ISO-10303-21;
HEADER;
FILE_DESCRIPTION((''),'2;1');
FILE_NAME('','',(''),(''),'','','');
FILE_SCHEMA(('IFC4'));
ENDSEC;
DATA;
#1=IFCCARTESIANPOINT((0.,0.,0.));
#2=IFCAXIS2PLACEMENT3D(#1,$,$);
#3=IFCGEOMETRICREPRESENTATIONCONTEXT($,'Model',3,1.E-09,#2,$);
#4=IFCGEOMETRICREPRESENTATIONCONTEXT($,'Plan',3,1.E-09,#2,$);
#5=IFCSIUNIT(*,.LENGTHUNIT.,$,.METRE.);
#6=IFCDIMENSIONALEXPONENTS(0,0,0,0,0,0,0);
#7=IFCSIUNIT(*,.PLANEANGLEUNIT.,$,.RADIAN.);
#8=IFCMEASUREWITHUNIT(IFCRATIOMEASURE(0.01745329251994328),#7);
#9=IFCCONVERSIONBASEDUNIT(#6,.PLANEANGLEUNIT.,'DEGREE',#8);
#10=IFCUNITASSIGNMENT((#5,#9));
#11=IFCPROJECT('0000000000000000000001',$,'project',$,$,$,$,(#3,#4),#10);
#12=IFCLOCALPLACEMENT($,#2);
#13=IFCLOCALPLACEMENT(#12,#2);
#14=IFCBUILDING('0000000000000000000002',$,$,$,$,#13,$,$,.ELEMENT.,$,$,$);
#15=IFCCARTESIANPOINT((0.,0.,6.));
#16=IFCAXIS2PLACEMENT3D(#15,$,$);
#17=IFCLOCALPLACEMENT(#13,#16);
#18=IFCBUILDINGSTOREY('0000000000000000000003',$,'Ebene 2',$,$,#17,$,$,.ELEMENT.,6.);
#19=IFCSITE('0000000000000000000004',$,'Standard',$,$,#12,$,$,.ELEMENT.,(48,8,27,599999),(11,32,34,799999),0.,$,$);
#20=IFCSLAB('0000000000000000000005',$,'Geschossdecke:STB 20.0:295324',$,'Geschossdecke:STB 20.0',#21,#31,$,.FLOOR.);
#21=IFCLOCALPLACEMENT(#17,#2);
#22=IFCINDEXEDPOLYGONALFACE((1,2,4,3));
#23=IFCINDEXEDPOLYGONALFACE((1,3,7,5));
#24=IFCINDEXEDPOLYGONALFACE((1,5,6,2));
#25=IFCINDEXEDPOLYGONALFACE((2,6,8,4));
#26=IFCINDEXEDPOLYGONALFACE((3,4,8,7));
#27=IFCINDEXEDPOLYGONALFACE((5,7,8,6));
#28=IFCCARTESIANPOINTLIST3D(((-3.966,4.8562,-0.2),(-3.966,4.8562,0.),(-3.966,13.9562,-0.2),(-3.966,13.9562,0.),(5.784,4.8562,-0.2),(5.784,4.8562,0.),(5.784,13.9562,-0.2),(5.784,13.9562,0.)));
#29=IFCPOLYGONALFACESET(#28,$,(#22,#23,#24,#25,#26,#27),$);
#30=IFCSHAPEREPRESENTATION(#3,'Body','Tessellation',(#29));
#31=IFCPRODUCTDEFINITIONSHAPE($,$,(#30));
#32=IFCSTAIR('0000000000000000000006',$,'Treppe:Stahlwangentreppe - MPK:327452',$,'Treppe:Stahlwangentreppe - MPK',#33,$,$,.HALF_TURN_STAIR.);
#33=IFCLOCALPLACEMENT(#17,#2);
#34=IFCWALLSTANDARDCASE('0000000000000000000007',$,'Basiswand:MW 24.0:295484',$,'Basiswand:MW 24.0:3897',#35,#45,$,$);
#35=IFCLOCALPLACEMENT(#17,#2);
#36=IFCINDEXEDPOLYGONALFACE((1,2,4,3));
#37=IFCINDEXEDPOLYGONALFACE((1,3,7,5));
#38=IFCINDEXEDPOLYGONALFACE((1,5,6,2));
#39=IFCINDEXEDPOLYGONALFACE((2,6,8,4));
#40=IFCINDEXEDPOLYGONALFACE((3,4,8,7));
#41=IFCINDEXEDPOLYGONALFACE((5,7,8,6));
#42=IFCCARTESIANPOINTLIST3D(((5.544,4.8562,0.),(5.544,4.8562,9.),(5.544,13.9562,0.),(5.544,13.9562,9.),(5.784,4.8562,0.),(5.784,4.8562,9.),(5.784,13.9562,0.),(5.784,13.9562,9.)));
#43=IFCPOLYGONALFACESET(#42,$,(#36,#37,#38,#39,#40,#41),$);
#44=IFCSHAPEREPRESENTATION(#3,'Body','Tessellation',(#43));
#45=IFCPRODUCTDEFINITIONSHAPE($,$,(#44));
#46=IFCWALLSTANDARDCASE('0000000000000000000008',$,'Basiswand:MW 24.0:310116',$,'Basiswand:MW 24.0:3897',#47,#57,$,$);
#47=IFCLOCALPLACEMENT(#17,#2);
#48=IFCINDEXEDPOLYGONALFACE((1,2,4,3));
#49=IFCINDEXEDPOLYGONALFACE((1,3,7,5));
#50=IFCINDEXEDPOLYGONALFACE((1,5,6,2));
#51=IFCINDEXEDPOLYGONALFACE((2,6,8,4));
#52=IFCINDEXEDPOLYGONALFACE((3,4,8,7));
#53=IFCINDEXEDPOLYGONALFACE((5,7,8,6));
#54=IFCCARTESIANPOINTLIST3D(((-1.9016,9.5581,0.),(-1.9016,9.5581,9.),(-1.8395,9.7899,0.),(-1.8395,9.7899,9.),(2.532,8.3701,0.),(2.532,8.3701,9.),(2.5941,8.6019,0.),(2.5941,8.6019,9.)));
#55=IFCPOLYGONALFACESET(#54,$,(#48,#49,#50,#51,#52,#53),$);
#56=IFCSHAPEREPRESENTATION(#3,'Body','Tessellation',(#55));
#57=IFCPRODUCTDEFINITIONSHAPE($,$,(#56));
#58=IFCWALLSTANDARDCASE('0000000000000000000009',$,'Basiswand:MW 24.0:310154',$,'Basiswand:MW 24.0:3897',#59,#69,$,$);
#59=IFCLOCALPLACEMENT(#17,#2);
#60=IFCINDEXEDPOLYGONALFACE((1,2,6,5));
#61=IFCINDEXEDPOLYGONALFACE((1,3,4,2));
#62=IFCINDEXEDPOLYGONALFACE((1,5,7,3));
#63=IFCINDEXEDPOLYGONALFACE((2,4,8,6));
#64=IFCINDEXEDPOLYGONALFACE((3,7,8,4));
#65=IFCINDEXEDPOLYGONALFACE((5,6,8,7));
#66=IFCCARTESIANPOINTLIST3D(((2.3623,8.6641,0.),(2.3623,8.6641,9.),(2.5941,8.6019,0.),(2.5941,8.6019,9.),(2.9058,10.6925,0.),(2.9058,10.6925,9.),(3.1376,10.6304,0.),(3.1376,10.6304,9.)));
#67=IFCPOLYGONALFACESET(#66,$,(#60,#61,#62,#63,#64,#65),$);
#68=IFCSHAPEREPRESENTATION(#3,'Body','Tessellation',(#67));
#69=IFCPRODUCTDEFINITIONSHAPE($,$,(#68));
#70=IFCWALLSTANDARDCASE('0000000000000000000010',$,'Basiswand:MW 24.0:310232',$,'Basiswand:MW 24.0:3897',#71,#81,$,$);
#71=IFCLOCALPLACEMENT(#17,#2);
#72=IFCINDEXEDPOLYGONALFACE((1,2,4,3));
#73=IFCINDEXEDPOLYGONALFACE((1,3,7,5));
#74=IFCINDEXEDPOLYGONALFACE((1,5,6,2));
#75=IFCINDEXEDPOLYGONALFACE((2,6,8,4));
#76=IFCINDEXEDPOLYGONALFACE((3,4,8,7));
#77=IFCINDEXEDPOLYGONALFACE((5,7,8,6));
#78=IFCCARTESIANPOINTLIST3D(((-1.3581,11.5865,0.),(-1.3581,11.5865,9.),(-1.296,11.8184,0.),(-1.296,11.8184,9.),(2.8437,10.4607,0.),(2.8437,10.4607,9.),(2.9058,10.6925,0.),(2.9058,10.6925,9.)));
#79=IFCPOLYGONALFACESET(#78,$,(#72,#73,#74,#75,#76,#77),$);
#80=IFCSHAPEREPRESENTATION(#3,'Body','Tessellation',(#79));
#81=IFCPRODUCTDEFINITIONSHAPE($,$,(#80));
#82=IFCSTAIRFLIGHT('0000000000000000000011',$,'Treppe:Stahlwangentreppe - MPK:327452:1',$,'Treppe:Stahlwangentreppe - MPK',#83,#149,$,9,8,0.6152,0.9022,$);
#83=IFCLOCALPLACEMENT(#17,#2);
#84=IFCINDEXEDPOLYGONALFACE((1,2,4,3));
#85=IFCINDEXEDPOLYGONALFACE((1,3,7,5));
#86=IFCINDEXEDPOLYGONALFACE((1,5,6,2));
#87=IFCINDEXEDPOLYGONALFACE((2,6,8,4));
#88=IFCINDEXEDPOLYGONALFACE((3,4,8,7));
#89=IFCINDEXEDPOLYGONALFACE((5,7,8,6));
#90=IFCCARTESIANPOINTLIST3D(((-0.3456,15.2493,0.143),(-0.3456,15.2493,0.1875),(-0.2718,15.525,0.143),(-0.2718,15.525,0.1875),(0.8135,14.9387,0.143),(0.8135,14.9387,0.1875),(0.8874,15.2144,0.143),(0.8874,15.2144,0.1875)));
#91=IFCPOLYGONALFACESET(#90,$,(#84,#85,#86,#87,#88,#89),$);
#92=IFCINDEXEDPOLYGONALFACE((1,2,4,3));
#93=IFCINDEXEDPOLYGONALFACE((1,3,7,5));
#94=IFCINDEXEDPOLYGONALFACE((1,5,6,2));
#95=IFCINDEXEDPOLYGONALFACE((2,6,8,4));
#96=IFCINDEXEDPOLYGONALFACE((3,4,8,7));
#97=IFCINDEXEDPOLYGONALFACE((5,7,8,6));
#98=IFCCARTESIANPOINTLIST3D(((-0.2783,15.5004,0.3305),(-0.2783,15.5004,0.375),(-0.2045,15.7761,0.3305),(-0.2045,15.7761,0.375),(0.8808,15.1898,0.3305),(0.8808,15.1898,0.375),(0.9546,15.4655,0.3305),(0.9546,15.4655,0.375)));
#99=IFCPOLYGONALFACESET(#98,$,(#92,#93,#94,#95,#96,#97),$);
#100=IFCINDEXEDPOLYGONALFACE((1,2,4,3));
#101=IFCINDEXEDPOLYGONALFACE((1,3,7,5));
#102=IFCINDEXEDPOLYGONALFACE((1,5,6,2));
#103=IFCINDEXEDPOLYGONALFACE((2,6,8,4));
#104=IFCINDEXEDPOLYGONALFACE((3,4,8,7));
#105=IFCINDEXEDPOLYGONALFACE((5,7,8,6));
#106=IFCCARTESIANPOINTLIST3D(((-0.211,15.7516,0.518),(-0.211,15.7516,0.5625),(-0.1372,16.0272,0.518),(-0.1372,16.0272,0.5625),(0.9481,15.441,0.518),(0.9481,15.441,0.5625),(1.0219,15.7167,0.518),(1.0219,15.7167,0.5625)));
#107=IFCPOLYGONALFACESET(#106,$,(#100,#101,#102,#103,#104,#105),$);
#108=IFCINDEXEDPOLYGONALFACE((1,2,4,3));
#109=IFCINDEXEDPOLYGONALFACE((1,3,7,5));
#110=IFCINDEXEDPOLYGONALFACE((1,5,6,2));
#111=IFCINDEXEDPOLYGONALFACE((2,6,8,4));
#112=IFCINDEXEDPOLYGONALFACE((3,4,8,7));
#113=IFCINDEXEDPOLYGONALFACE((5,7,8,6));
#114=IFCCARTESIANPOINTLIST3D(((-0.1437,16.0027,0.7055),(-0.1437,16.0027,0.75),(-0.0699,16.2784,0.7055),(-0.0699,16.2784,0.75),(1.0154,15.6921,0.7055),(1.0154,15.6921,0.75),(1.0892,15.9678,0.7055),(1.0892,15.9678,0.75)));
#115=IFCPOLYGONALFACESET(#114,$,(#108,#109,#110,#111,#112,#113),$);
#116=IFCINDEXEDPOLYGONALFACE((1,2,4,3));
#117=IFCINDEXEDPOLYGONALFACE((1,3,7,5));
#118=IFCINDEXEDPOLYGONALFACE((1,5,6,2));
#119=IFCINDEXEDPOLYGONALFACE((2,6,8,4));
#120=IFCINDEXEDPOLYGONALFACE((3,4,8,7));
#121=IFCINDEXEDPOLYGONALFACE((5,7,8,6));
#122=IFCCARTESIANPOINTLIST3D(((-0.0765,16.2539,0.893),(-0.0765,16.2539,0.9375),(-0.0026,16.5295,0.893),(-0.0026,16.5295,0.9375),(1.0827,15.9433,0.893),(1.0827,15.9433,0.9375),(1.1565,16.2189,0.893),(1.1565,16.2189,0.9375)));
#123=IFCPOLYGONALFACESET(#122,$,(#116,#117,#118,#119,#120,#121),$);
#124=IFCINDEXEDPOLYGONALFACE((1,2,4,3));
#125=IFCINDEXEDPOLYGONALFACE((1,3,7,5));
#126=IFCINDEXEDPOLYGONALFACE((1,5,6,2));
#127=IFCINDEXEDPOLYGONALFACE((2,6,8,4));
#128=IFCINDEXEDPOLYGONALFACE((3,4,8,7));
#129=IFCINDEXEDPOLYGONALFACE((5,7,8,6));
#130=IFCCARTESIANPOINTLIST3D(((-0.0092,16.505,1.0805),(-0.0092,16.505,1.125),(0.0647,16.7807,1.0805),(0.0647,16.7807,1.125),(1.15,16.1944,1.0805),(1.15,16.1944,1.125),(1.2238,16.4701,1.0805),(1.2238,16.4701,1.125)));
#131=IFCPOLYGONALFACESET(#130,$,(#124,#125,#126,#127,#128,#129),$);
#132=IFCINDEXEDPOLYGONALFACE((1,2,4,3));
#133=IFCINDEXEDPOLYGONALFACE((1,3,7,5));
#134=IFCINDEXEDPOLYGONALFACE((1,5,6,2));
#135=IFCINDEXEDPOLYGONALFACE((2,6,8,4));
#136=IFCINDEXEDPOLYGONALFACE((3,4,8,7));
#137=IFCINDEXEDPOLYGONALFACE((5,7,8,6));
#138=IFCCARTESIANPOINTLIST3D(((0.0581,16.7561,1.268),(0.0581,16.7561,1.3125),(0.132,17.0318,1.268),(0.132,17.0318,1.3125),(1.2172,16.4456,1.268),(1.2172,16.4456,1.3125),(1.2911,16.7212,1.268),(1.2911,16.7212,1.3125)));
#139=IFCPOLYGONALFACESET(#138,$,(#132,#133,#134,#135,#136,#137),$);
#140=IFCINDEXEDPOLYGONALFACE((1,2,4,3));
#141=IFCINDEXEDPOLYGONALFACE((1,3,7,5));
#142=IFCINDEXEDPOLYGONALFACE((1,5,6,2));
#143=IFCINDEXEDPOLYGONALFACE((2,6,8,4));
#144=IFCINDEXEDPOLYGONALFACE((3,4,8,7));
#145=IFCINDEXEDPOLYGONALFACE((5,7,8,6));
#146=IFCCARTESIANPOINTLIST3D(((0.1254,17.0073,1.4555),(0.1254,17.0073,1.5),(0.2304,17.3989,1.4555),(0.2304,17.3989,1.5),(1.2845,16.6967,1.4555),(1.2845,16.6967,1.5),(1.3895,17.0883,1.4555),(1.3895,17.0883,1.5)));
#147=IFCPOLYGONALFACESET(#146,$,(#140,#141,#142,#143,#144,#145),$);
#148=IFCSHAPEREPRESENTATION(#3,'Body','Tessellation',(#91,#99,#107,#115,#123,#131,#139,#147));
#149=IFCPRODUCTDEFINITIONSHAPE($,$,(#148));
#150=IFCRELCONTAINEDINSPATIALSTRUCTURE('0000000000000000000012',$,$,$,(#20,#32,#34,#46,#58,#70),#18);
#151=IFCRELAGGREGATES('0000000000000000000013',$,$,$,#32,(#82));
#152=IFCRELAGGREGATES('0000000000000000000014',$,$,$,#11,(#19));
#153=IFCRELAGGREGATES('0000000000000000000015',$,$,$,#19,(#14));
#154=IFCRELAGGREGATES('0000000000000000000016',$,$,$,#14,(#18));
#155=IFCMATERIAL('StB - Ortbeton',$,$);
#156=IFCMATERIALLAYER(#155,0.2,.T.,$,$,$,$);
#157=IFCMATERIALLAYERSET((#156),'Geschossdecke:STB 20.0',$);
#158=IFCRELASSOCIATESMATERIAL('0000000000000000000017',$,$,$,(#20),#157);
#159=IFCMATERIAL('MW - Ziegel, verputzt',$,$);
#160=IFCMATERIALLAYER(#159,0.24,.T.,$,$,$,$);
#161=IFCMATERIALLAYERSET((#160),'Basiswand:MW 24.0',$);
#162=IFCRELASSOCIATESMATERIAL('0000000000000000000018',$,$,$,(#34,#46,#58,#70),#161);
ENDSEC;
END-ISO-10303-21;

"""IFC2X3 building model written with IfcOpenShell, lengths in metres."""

from ifc_helpers import new_model, entity, si_unit, converted_unit, frame, frame_2d, origin, origin_2d_with_axis, place, context, project, spatial, rectangle, extrude, material, layer, layer_set, layer_usage, element, aggregate, save


model = new_model("IFC2X3")

# Units and contexts
model_context = context("Model", 3, precision=1e-09, world=origin())
plan_context = context("Plan", 3, precision=1e-09, world=origin())
ifc_project = project(units=[si_unit("LENGTHUNIT", "METRE"), converted_unit("PLANEANGLEUNIT", "DEGREE", entity("IfcRatioMeasure", 0.01745329251994328), si_unit("PLANEANGLEUNIT", "RADIAN"), dimensions=[0, 0, 0, 0, 0, 0, 0])], contexts=[model_context, plan_context])

# Site, building, storey
site_placement = place(None, origin())
site = spatial("IfcSite", under=ifc_project, at=site_placement, Name="Standard", CompositionType="ELEMENT", RefLatitude=(48, 8, 27, 599999), RefLongitude=(11, 32, 34, 799999), RefElevation=0.0)
building_placement = place(site_placement, origin())
building = spatial("IfcBuilding", under=site, at=building_placement, CompositionType="ELEMENT")
storey_placement = place(building_placement, frame((0.0, 0.0, 6.0)))
storey = spatial("IfcBuildingStorey", under=building, at=storey_placement, Name="Ebene 2", CompositionType="ELEMENT", Elevation=6.0)

# Slab
ifc_material_1 = material(Name="StB - Ortbeton")
ifc_layer_1 = layer(ifc_material_1, 0.2, ventilated=True)
ifc_layer_set_1 = layer_set([ifc_layer_1], Name="Geschossdecke:STB 20.0")
ifc_layer_usage_1 = layer_usage(ifc_layer_set_1, "AXIS3", "POSITIVE", 0.0)
slab_1_placement = place(storey_placement, frame((-3.966, 4.8562, -0.2)))
element("IfcSlab", 1, at=slab_1_placement, inside=storey, material=ifc_layer_usage_1, Name="Geschossdecke:STB 20.0:295324", ObjectType="Geschossdecke:STB 20.0", PredefinedType="FLOOR", context=model_context, shape_type="SweptSolid", body=[
    extrude(rectangle(XDim=9.1, YDim=9.75, at=frame_2d((0.0, 0.0), x_axis=(0.0, -1.0))), frame((4.875, 4.55, 0.2), z_axis=(0.0, 0.0, -1.0), x_axis=(-1.0, 0.0, 0.0)), (0.0, 0.0, 1.0), 0.2),
])

# Stair
stair_placement = place(storey_placement, origin())
stair = element("IfcStair", 2, at=stair_placement, inside=storey, Name="Treppe:Stahlwangentreppe - MPK:327452", ObjectType="Treppe:Stahlwangentreppe - MPK", ShapeType="HALF_TURN_STAIR")

# Wall
ifc_material_2 = material(Name="MW - Ziegel, verputzt")
ifc_layer_2 = layer(ifc_material_2, 0.24, ventilated=True)
ifc_layer_set_2 = layer_set([ifc_layer_2], Name="Basiswand:MW 24.0")
ifc_layer_usage_2 = layer_usage(ifc_layer_set_2, "AXIS2", "NEGATIVE", 0.12)
wall_1_placement = place(storey_placement, frame((5.664, 4.8562, 0.0), z_axis=(0.0, 0.0, 1.0), x_axis=(0.0, 1.0, 0.0)))
element("IfcWallStandardCase", 3, at=wall_1_placement, inside=storey, material=ifc_layer_usage_2, Name="Basiswand:MW 24.0:295484", ObjectType="Basiswand:MW 24.0:3897", context=model_context, shape_type="SweptSolid", body=[
    extrude(rectangle(XDim=9.1, YDim=0.24, at=frame_2d((4.55, 0.0), x_axis=(-1.0, 0.0))), origin(), (0.0, 0.0, 1.0), 9.0),
])

# Walls
ifc_layer_usage_3 = layer_usage(ifc_layer_set_2, "AXIS2", "NEGATIVE", 0.12)
wall_2_placement = place(storey_placement, frame((-1.8706, 9.674, 0.0), z_axis=(0.0, 0.0, 1.0), x_axis=(0.965926, -0.258819, 0.0)))
element("IfcWallStandardCase", 4, at=wall_2_placement, inside=storey, material=ifc_layer_usage_3, Name="Basiswand:MW 24.0:310116", ObjectType="Basiswand:MW 24.0:3897", context=model_context, shape_type="SweptSolid", body=[
    extrude(rectangle(XDim=4.59, YDim=0.24, at=frame_2d((2.295, 0.0), x_axis=(-1.0, 0.0))), origin(), (0.0, 0.0, 1.0), 9.0),
])
ifc_layer_usage_4 = layer_usage(ifc_layer_set_2, "AXIS2", "NEGATIVE", 0.12)
wall_3_placement = place(storey_placement, frame((2.4782, 8.633, 0.0), z_axis=(0.0, 0.0, 1.0), x_axis=(0.258819, 0.965926, 0.0)))
element("IfcWallStandardCase", 5, at=wall_3_placement, inside=storey, material=ifc_layer_usage_4, Name="Basiswand:MW 24.0:310154", ObjectType="Basiswand:MW 24.0:3897", context=model_context, shape_type="SweptSolid", body=[
    extrude(rectangle(XDim=2.1, YDim=0.24, at=frame_2d((1.05, 0.0), x_axis=(-1.0, 0.0))), origin(), (0.0, 0.0, 1.0), 9.0),
])
ifc_layer_usage_5 = layer_usage(ifc_layer_set_2, "AXIS2", "NEGATIVE", 0.12)
wall_4_placement = place(storey_placement, frame((2.8747, 10.5766, 0.0), z_axis=(0.0, 0.0, 1.0), x_axis=(-0.965926, 0.258819, 0.0)))
element("IfcWallStandardCase", 6, at=wall_4_placement, inside=storey, material=ifc_layer_usage_5, Name="Basiswand:MW 24.0:310232", ObjectType="Basiswand:MW 24.0:3897", context=model_context, shape_type="SweptSolid", body=[
    extrude(rectangle(XDim=4.35, YDim=0.24, at=frame_2d((2.175, 0.0), x_axis=(-1.0, 0.0))), origin(), (0.0, 0.0, 1.0), 9.0),
])

# Stair flight
stair_flight_1_placement = place(storey_placement, origin())
stair_flight_1 = element("IfcStairFlight", 7, at=stair_flight_1_placement, Name="Treppe:Stahlwangentreppe - MPK:327452:1", ObjectType="Treppe:Stahlwangentreppe - MPK", NumberOfRiser=9, NumberOfTreads=8, RiserHeight=0.6152, TreadLength=0.9022, context=model_context, shape_type="SweptSolid", body=[
    extrude(rectangle(XDim=0.2854, YDim=1.2, at=origin_2d_with_axis()), frame((0.2709, 15.2318, 0.1431), z_axis=(0.0, 0.0, 1.0), x_axis=(-0.258819, -0.965926, 0.0)), (0.0, 0.0, 1.0), 0.0445),
    extrude(rectangle(XDim=0.2854, YDim=1.2, at=origin_2d_with_axis()), frame((0.3382, 15.483, 0.3306), z_axis=(0.0, 0.0, 1.0), x_axis=(-0.258819, -0.965926, 0.0)), (0.0, 0.0, 1.0), 0.0445),
    extrude(rectangle(XDim=0.2854, YDim=1.2, at=origin_2d_with_axis()), frame((0.4055, 15.7341, 0.518), z_axis=(0.0, 0.0, 1.0), x_axis=(-0.258819, -0.965926, 0.0)), (0.0, 0.0, 1.0), 0.0445),
    extrude(rectangle(XDim=0.2854, YDim=1.2, at=origin_2d_with_axis()), frame((0.4727, 15.9853, 0.7055), z_axis=(0.0, 0.0, 1.0), x_axis=(-0.258819, -0.965926, 0.0)), (0.0, 0.0, 1.0), 0.0445),
    extrude(rectangle(XDim=0.2854, YDim=1.2, at=origin_2d_with_axis()), frame((0.54, 16.2364, 0.893), z_axis=(0.0, 0.0, 1.0), x_axis=(-0.258819, -0.965926, 0.0)), (0.0, 0.0, 1.0), 0.0445),
    extrude(rectangle(XDim=0.2854, YDim=1.2, at=origin_2d_with_axis()), frame((0.6073, 16.4875, 1.0805), z_axis=(0.0, 0.0, 1.0), x_axis=(-0.258819, -0.965926, 0.0)), (0.0, 0.0, 1.0), 0.0445),
    extrude(rectangle(XDim=0.2854, YDim=1.2, at=origin_2d_with_axis()), frame((0.6746, 16.7387, 1.268), z_axis=(0.0, 0.0, 1.0), x_axis=(-0.258819, -0.965926, 0.0)), (0.0, 0.0, 1.0), 0.0444),
    extrude(rectangle(XDim=0.4054, YDim=1.2, at=frame_2d((0.0355, 0.12), x_axis=(1.0, 0.0))), frame((0.6507, 17.1131, 1.4555), z_axis=(0.0, 0.0, 1.0), x_axis=(-0.258819, -0.965926, 0.0)), (0.0, 0.0, 1.0), 0.0444),
])
aggregate(stair, [stair_flight_1])

save(model, "model.ifc")
